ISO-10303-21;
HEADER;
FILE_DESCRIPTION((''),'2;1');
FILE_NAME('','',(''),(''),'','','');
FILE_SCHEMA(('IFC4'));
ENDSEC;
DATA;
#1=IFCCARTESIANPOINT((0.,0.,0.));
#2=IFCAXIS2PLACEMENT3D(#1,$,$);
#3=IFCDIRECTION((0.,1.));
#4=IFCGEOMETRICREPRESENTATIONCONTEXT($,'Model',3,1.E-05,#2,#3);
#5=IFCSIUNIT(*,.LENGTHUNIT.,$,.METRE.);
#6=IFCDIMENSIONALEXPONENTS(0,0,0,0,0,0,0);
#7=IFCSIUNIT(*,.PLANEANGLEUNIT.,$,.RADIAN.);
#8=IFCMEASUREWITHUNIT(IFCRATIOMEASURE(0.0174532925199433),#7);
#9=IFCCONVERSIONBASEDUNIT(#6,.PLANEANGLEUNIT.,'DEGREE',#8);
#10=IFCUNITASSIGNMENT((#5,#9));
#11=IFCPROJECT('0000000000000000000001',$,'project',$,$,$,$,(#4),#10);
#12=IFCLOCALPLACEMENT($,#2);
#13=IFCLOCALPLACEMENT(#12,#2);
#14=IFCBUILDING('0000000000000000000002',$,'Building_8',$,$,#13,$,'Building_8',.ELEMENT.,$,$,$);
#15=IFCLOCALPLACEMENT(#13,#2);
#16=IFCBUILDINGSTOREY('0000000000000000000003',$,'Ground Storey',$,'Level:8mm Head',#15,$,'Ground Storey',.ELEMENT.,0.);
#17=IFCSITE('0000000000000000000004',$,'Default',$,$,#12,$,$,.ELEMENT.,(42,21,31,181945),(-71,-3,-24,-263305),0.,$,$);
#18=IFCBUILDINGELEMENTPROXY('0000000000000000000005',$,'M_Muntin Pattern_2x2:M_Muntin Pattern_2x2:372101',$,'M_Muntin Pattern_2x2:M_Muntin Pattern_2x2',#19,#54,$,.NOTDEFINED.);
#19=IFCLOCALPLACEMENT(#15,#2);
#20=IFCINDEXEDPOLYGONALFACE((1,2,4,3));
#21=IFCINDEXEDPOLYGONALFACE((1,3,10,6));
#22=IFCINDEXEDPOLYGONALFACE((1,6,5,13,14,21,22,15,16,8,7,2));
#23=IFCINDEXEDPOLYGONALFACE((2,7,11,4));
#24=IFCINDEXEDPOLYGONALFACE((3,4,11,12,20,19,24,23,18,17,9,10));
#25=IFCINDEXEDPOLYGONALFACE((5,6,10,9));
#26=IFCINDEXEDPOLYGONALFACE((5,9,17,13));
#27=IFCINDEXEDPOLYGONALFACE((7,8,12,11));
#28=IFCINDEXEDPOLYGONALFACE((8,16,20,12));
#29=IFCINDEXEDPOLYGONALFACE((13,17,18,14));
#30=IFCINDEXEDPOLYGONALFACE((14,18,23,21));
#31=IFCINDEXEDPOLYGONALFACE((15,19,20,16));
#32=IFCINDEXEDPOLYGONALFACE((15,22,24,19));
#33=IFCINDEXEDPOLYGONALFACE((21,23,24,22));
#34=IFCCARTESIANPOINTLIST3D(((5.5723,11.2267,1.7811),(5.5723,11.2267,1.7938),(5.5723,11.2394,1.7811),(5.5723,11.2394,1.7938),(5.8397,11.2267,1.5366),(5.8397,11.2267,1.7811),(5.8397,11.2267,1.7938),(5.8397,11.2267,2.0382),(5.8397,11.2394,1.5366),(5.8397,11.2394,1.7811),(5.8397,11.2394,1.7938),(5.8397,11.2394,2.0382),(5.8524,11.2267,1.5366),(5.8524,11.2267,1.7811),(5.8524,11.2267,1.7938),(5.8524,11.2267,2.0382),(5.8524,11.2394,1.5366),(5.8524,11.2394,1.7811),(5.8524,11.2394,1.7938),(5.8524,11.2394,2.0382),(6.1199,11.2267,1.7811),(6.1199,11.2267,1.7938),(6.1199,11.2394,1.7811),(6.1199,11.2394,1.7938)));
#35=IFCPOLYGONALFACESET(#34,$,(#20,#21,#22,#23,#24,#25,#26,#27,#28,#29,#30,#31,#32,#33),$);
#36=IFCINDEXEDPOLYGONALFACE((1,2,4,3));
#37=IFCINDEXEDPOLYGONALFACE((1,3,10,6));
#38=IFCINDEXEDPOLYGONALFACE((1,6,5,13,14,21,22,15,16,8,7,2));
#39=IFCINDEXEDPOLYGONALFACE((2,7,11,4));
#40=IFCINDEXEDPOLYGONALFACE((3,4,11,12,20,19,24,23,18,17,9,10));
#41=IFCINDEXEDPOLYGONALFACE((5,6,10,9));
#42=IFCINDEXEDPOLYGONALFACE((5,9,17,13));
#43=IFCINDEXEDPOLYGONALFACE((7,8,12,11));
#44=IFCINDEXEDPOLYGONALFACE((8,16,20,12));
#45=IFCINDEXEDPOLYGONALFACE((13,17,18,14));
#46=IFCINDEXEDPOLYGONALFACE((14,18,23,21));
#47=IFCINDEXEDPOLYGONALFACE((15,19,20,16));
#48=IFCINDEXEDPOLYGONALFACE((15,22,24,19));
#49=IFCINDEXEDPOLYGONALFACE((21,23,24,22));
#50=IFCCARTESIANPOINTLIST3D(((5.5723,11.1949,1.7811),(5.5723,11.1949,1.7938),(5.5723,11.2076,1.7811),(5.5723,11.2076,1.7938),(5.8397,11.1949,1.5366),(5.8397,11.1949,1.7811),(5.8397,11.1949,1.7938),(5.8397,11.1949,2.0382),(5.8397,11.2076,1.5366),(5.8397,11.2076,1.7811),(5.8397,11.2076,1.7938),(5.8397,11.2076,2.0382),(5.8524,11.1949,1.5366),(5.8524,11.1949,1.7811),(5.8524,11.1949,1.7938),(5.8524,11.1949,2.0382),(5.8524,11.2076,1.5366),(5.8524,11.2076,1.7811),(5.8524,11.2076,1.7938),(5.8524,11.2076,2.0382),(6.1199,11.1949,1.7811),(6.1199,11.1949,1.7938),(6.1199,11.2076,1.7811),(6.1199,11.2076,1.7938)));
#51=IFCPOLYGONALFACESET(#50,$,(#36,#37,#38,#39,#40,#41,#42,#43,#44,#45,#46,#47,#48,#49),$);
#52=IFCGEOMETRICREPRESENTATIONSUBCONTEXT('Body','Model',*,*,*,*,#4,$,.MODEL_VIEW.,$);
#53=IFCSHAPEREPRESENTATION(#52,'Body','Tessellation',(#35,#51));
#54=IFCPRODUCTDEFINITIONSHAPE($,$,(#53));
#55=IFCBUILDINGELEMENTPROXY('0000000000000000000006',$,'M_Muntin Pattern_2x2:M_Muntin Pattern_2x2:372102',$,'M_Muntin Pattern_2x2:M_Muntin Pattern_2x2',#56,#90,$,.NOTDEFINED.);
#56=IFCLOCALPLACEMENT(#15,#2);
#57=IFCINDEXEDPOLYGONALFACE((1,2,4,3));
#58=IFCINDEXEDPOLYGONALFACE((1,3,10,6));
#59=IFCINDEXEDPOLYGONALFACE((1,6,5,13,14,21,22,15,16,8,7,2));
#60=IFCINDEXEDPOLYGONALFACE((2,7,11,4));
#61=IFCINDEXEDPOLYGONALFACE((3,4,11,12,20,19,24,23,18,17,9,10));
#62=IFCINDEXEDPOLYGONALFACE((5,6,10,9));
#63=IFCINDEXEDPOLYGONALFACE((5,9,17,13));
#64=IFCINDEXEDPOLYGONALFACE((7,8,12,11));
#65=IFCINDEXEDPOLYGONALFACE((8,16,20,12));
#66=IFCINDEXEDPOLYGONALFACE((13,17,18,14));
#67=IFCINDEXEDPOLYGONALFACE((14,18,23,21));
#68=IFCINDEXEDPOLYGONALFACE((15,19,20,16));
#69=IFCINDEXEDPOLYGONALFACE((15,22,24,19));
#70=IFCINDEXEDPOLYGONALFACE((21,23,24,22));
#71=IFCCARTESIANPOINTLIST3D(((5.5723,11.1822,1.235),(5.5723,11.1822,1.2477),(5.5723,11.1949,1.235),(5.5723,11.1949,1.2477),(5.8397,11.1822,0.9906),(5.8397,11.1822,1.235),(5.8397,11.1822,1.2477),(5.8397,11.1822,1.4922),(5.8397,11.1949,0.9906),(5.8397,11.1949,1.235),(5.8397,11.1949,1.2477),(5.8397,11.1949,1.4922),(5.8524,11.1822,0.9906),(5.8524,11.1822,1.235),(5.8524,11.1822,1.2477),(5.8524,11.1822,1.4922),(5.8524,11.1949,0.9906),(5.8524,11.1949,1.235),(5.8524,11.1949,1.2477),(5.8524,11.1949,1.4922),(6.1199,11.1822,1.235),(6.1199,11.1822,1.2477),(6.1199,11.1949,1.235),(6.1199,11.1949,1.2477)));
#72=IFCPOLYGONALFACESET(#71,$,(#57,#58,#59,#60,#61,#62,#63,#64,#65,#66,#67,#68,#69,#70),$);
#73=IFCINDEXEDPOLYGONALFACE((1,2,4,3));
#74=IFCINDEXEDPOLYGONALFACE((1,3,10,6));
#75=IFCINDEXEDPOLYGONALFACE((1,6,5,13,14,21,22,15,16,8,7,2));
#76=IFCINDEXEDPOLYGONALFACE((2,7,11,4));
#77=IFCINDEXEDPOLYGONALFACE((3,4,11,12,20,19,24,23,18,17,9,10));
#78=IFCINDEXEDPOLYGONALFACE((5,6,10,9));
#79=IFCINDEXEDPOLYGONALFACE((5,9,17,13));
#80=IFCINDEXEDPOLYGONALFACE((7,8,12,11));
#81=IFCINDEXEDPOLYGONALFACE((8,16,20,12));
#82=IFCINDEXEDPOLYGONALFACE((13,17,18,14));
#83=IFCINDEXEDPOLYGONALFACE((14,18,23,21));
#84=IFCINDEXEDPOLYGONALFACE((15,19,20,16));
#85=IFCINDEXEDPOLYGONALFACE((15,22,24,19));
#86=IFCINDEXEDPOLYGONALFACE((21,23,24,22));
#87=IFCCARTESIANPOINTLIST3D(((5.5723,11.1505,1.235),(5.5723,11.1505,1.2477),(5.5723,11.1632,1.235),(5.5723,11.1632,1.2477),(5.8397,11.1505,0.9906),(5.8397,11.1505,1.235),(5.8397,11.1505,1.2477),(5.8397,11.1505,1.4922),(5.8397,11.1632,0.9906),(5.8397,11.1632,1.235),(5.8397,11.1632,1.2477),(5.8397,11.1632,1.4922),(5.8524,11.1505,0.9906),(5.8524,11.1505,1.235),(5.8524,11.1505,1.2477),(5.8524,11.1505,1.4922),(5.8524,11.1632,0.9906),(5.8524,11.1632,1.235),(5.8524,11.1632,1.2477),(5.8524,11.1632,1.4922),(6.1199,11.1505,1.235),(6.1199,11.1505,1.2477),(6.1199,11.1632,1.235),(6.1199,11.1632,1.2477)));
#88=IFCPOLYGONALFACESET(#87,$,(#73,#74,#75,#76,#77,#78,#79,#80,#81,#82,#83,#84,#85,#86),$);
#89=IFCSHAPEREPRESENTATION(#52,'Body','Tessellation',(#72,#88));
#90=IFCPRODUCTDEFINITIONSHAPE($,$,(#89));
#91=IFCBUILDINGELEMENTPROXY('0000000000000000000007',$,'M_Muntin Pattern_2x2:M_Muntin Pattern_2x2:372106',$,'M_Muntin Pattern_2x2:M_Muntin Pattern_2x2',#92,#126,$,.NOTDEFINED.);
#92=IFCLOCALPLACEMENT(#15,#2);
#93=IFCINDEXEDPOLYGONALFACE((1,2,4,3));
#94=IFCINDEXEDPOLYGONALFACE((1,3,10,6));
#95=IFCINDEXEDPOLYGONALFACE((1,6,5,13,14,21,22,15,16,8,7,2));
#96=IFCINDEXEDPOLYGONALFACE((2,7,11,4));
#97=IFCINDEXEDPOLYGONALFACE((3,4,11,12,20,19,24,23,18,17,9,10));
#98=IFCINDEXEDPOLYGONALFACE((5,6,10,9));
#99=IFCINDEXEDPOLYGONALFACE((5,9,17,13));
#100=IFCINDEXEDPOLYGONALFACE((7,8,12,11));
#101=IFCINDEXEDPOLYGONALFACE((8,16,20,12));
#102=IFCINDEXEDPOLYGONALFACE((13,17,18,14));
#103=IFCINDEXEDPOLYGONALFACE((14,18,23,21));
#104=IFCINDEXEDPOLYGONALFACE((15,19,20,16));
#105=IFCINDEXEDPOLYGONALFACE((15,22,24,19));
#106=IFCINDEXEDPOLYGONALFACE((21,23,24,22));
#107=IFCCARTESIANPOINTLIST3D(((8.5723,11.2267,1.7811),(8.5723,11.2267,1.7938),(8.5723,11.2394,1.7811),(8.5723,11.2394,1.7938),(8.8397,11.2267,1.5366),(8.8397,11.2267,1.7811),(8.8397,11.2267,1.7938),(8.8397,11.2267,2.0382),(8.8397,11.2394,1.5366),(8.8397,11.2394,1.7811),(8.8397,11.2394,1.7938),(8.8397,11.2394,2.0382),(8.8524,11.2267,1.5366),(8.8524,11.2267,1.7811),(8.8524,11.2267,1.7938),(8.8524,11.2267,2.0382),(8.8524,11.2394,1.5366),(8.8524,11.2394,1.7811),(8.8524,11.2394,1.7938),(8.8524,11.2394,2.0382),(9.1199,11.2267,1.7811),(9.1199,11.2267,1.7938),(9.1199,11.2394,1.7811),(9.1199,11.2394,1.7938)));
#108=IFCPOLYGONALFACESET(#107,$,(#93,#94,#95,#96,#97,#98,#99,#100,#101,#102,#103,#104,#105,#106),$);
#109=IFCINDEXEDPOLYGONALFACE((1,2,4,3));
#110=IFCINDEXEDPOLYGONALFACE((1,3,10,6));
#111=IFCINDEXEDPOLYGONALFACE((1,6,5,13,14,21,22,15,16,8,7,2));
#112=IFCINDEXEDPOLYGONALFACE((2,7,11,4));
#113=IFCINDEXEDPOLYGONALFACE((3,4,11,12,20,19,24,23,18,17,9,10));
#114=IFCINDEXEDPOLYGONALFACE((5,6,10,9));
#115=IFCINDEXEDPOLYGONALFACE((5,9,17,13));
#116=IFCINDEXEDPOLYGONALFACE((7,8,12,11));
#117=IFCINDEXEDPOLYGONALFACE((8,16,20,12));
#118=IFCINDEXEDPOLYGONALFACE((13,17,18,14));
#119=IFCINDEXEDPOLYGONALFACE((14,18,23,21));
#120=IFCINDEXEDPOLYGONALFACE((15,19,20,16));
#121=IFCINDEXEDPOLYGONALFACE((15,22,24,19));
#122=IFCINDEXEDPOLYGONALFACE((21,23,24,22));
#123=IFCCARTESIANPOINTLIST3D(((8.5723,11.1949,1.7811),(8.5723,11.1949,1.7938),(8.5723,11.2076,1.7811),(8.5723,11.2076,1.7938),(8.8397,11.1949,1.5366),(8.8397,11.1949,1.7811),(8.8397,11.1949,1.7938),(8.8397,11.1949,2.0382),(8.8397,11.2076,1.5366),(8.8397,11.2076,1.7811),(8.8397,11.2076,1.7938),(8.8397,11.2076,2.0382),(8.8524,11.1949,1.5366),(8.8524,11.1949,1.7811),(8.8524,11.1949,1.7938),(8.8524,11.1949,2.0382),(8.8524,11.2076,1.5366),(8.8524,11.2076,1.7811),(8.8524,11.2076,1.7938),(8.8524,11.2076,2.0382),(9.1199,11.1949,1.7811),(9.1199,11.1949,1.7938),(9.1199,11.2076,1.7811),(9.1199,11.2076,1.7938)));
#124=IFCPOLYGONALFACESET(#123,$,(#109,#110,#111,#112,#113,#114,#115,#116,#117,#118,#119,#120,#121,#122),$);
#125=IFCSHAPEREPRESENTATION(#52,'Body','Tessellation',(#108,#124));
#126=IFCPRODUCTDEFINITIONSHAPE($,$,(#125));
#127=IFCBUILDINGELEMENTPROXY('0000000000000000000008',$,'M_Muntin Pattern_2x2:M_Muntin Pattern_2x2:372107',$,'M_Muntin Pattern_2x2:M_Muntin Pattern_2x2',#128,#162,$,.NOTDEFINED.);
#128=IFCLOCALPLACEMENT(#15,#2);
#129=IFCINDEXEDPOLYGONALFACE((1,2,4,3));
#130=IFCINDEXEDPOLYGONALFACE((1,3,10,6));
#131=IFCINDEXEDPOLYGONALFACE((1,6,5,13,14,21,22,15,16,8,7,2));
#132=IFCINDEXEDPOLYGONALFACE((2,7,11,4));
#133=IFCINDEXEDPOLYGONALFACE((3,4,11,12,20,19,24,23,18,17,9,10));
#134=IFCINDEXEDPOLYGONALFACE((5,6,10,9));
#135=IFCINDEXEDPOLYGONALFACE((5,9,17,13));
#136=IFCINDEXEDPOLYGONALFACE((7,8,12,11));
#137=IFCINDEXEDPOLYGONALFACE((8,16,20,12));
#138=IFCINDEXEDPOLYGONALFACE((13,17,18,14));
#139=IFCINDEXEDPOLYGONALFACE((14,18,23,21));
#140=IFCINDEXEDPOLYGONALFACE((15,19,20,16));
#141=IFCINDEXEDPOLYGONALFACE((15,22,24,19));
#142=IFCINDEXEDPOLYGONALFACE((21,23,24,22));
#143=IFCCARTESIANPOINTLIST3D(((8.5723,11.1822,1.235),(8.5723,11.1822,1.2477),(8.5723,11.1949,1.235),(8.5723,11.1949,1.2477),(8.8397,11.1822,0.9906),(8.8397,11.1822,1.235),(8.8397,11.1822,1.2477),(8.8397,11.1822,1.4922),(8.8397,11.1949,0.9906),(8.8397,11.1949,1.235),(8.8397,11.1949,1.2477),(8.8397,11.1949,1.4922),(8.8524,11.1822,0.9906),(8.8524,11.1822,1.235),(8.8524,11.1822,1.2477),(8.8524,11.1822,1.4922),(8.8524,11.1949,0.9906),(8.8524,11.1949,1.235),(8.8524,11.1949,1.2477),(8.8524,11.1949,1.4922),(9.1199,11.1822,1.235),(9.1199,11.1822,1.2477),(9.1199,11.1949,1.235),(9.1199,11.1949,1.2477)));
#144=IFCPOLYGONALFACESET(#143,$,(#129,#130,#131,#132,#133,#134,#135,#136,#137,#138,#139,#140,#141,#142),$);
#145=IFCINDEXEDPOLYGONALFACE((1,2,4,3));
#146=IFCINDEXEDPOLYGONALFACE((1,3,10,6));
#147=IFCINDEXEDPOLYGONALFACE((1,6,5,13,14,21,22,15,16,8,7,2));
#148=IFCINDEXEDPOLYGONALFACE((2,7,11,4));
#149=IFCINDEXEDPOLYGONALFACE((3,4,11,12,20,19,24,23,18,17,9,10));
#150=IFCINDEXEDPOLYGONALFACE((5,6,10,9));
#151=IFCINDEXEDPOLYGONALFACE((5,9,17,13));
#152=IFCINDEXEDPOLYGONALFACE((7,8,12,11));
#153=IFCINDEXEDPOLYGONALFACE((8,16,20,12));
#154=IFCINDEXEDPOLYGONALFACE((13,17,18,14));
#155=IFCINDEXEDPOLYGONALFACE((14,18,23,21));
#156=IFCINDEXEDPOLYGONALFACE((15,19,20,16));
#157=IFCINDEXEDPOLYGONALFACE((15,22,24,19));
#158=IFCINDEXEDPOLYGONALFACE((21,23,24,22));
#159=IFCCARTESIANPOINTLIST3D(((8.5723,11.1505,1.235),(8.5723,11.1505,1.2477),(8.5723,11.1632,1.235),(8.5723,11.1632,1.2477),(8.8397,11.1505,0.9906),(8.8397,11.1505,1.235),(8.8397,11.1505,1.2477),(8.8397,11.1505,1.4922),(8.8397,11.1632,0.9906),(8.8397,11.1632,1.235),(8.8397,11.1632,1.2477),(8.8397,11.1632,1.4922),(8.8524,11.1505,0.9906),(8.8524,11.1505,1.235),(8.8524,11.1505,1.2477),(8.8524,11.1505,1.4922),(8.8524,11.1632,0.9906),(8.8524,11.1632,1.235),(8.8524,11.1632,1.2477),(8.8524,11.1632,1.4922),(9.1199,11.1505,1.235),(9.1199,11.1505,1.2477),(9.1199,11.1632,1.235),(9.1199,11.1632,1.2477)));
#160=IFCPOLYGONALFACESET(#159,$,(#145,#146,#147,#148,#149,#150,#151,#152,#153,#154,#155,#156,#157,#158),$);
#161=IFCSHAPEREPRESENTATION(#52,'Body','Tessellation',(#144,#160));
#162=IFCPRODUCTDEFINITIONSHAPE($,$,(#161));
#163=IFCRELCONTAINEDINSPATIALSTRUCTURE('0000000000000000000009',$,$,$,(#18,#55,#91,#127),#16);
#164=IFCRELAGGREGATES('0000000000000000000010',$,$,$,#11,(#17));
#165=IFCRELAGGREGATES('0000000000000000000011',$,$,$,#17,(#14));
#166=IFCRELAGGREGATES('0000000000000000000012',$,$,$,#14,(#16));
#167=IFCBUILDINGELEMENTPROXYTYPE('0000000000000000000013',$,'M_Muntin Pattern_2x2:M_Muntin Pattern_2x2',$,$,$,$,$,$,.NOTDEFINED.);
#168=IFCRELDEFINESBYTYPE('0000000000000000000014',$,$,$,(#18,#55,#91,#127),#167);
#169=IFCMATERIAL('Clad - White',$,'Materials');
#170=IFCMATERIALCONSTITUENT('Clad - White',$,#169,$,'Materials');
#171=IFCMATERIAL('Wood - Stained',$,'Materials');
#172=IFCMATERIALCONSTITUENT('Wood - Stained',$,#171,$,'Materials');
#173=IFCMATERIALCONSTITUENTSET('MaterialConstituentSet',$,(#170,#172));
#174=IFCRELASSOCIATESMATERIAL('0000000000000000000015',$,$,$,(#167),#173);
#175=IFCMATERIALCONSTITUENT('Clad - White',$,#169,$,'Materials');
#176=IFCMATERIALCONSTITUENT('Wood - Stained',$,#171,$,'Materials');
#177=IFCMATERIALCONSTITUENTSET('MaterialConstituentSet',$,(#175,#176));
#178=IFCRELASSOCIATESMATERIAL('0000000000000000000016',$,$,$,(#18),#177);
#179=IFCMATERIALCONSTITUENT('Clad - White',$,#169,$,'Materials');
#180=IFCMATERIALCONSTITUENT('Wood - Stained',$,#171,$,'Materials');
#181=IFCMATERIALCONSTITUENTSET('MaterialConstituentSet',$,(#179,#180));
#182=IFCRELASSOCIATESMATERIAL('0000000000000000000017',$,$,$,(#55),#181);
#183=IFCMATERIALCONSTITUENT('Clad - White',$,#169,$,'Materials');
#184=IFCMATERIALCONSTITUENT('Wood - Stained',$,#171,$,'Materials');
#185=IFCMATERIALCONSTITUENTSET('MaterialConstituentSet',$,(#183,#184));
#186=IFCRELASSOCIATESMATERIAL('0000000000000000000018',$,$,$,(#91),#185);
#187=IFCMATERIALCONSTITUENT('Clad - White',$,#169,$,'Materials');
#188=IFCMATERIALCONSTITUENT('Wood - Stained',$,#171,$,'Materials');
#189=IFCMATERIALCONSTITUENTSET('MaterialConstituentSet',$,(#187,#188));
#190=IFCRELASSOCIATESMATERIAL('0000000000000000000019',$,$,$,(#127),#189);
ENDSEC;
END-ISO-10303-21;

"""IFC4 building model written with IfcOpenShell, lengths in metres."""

from ifc_helpers import new_model, entity, si_unit, converted_unit, direction, frame, origin, place, context, subcontext, project, spatial, indexed_curve, outline, extrude, source, transform, mapped, material, constituent, constituent_set, type_object, type_shapes, element, save


model = new_model("IFC4")

# Units and contexts
model_context = context("Model", 3, precision=1e-05, world=origin(), true_north=direction((0.0, 1.0)))
body_context = subcontext(model_context, "Body", "Model", "MODEL_VIEW")
ifc_project = project(units=[si_unit("LENGTHUNIT", "METRE"), converted_unit("PLANEANGLEUNIT", "DEGREE", entity("IfcRatioMeasure", 0.0174532925199433), si_unit("PLANEANGLEUNIT", "RADIAN"), dimensions=[0, 0, 0, 0, 0, 0, 0])], contexts=[model_context])

# Site, building, storey
site_placement = place(None, origin())
site = spatial("IfcSite", under=ifc_project, at=site_placement, Name="Default", CompositionType="ELEMENT", RefLatitude=(42, 21, 31, 181945), RefLongitude=(-71, -3, -24, -263305), RefElevation=0.0)
building_placement = place(site_placement, origin())
building = spatial("IfcBuilding", under=site, at=building_placement, Name="Building_8", LongName="Building_8", CompositionType="ELEMENT")
storey_placement = place(building_placement, origin())
storey = spatial("IfcBuildingStorey", under=building, at=storey_placement, Name="Ground Storey", ObjectType="Level:8mm Head", LongName="Ground Storey", CompositionType="ELEMENT", Elevation=0.0)

# Building element proxies
ifc_material_1 = material(Name="Clad - White", Category="Materials")
ifc_material_2 = material(Name="Wood - Stained", Category="Materials")
ifc_constituent_1 = constituent(ifc_material_1, Name="Clad - White", Category="Materials")
ifc_constituent_2 = constituent(ifc_material_2, Name="Wood - Stained", Category="Materials")
ifc_constituent_set_1 = constituent_set(constituents=[ifc_constituent_1, ifc_constituent_2], Name="MaterialConstituentSet")
building_element_proxy_type_1 = type_object("IfcBuildingElementProxyType", Name="M_Muntin Pattern_2x2:M_Muntin Pattern_2x2", PredefinedType="NOTDEFINED", material=ifc_constituent_set_1)
shared_shape_1 = source(origin(), body_context, "Body", "SweptSolid", [
    extrude(outline(indexed_curve([(0.0064, -0.0064), (0.2508, -0.0064), (0.2508, 0.0063), (0.0064, 0.0063), (0.0064, 0.2738), (-0.0063, 0.2738), (-0.0063, 0.0063), (-0.2508, 0.0063), (-0.2508, -0.0064), (-0.0063, -0.0064), (-0.0063, -0.2738), (0.0064, -0.2738), (0.0064, -0.0064)], self_intersect=False)), frame((0.0, 0.0095, 0.2508), z_axis=(0.0, 1.0, 0.0), x_axis=(0.0, 0.0, 1.0)), (0.0, 0.0, 1.0), 0.0127),
    extrude(outline(indexed_curve([(0.0064, -0.0064), (0.2508, -0.0064), (0.2508, 0.0063), (0.0064, 0.0063), (0.0064, 0.2738), (-0.0063, 0.2738), (-0.0063, 0.0063), (-0.2508, 0.0063), (-0.2508, -0.0064), (-0.0063, -0.0064), (-0.0063, -0.2738), (0.0064, -0.2738), (0.0064, -0.0064)], self_intersect=False)), frame((0.0, -0.0222, 0.2508), z_axis=(0.0, 1.0, 0.0), x_axis=(0.0, 0.0, 1.0)), (0.0, 0.0, 1.0), 0.0127),
])
type_shapes(building_element_proxy_type_1, [shared_shape_1])
ifc_constituent_3 = constituent(ifc_material_1, Name="Clad - White", Category="Materials")
ifc_constituent_4 = constituent(ifc_material_2, Name="Wood - Stained", Category="Materials")
ifc_constituent_set_2 = constituent_set(constituents=[ifc_constituent_3, ifc_constituent_4], Name="MaterialConstituentSet")
proxy_1_placement = place(storey_placement, frame((5.8461, 11.2171, 1.5366)))
element("IfcBuildingElementProxy", 1, at=proxy_1_placement, inside=storey, type_object=building_element_proxy_type_1, material=ifc_constituent_set_2, Name="M_Muntin Pattern_2x2:M_Muntin Pattern_2x2:372101", ObjectType="M_Muntin Pattern_2x2:M_Muntin Pattern_2x2", PredefinedType="NOTDEFINED", context=body_context, shape_type="MappedRepresentation", body=[
    mapped(shared_shape_1, transform((0.0, 0.0, 0.0), scale=1.0)),
])
ifc_constituent_5 = constituent(ifc_material_1, Name="Clad - White", Category="Materials")
ifc_constituent_6 = constituent(ifc_material_2, Name="Wood - Stained", Category="Materials")
ifc_constituent_set_3 = constituent_set(constituents=[ifc_constituent_5, ifc_constituent_6], Name="MaterialConstituentSet")
proxy_2_placement = place(storey_placement, frame((5.8461, 11.1727, 0.9906)))
element("IfcBuildingElementProxy", 2, at=proxy_2_placement, inside=storey, type_object=building_element_proxy_type_1, material=ifc_constituent_set_3, Name="M_Muntin Pattern_2x2:M_Muntin Pattern_2x2:372102", ObjectType="M_Muntin Pattern_2x2:M_Muntin Pattern_2x2", PredefinedType="NOTDEFINED", context=body_context, shape_type="MappedRepresentation", body=[
    mapped(shared_shape_1, transform((0.0, 0.0, 0.0), scale=1.0)),
])
ifc_constituent_7 = constituent(ifc_material_1, Name="Clad - White", Category="Materials")
ifc_constituent_8 = constituent(ifc_material_2, Name="Wood - Stained", Category="Materials")
ifc_constituent_set_4 = constituent_set(constituents=[ifc_constituent_7, ifc_constituent_8], Name="MaterialConstituentSet")
proxy_3_placement = place(storey_placement, frame((8.8461, 11.2171, 1.5366)))
element("IfcBuildingElementProxy", 3, at=proxy_3_placement, inside=storey, type_object=building_element_proxy_type_1, material=ifc_constituent_set_4, Name="M_Muntin Pattern_2x2:M_Muntin Pattern_2x2:372106", ObjectType="M_Muntin Pattern_2x2:M_Muntin Pattern_2x2", PredefinedType="NOTDEFINED", context=body_context, shape_type="MappedRepresentation", body=[
    mapped(shared_shape_1, transform((0.0, 0.0, 0.0), scale=1.0)),
])
ifc_constituent_9 = constituent(ifc_material_1, Name="Clad - White", Category="Materials")
ifc_constituent_10 = constituent(ifc_material_2, Name="Wood - Stained", Category="Materials")
ifc_constituent_set_5 = constituent_set(constituents=[ifc_constituent_9, ifc_constituent_10], Name="MaterialConstituentSet")
proxy_4_placement = place(storey_placement, frame((8.8461, 11.1727, 0.9906)))
element("IfcBuildingElementProxy", 4, at=proxy_4_placement, inside=storey, type_object=building_element_proxy_type_1, material=ifc_constituent_set_5, Name="M_Muntin Pattern_2x2:M_Muntin Pattern_2x2:372107", ObjectType="M_Muntin Pattern_2x2:M_Muntin Pattern_2x2", PredefinedType="NOTDEFINED", context=body_context, shape_type="MappedRepresentation", body=[
    mapped(shared_shape_1, transform((0.0, 0.0, 0.0), scale=1.0)),
])

save(model, "model.ifc")
